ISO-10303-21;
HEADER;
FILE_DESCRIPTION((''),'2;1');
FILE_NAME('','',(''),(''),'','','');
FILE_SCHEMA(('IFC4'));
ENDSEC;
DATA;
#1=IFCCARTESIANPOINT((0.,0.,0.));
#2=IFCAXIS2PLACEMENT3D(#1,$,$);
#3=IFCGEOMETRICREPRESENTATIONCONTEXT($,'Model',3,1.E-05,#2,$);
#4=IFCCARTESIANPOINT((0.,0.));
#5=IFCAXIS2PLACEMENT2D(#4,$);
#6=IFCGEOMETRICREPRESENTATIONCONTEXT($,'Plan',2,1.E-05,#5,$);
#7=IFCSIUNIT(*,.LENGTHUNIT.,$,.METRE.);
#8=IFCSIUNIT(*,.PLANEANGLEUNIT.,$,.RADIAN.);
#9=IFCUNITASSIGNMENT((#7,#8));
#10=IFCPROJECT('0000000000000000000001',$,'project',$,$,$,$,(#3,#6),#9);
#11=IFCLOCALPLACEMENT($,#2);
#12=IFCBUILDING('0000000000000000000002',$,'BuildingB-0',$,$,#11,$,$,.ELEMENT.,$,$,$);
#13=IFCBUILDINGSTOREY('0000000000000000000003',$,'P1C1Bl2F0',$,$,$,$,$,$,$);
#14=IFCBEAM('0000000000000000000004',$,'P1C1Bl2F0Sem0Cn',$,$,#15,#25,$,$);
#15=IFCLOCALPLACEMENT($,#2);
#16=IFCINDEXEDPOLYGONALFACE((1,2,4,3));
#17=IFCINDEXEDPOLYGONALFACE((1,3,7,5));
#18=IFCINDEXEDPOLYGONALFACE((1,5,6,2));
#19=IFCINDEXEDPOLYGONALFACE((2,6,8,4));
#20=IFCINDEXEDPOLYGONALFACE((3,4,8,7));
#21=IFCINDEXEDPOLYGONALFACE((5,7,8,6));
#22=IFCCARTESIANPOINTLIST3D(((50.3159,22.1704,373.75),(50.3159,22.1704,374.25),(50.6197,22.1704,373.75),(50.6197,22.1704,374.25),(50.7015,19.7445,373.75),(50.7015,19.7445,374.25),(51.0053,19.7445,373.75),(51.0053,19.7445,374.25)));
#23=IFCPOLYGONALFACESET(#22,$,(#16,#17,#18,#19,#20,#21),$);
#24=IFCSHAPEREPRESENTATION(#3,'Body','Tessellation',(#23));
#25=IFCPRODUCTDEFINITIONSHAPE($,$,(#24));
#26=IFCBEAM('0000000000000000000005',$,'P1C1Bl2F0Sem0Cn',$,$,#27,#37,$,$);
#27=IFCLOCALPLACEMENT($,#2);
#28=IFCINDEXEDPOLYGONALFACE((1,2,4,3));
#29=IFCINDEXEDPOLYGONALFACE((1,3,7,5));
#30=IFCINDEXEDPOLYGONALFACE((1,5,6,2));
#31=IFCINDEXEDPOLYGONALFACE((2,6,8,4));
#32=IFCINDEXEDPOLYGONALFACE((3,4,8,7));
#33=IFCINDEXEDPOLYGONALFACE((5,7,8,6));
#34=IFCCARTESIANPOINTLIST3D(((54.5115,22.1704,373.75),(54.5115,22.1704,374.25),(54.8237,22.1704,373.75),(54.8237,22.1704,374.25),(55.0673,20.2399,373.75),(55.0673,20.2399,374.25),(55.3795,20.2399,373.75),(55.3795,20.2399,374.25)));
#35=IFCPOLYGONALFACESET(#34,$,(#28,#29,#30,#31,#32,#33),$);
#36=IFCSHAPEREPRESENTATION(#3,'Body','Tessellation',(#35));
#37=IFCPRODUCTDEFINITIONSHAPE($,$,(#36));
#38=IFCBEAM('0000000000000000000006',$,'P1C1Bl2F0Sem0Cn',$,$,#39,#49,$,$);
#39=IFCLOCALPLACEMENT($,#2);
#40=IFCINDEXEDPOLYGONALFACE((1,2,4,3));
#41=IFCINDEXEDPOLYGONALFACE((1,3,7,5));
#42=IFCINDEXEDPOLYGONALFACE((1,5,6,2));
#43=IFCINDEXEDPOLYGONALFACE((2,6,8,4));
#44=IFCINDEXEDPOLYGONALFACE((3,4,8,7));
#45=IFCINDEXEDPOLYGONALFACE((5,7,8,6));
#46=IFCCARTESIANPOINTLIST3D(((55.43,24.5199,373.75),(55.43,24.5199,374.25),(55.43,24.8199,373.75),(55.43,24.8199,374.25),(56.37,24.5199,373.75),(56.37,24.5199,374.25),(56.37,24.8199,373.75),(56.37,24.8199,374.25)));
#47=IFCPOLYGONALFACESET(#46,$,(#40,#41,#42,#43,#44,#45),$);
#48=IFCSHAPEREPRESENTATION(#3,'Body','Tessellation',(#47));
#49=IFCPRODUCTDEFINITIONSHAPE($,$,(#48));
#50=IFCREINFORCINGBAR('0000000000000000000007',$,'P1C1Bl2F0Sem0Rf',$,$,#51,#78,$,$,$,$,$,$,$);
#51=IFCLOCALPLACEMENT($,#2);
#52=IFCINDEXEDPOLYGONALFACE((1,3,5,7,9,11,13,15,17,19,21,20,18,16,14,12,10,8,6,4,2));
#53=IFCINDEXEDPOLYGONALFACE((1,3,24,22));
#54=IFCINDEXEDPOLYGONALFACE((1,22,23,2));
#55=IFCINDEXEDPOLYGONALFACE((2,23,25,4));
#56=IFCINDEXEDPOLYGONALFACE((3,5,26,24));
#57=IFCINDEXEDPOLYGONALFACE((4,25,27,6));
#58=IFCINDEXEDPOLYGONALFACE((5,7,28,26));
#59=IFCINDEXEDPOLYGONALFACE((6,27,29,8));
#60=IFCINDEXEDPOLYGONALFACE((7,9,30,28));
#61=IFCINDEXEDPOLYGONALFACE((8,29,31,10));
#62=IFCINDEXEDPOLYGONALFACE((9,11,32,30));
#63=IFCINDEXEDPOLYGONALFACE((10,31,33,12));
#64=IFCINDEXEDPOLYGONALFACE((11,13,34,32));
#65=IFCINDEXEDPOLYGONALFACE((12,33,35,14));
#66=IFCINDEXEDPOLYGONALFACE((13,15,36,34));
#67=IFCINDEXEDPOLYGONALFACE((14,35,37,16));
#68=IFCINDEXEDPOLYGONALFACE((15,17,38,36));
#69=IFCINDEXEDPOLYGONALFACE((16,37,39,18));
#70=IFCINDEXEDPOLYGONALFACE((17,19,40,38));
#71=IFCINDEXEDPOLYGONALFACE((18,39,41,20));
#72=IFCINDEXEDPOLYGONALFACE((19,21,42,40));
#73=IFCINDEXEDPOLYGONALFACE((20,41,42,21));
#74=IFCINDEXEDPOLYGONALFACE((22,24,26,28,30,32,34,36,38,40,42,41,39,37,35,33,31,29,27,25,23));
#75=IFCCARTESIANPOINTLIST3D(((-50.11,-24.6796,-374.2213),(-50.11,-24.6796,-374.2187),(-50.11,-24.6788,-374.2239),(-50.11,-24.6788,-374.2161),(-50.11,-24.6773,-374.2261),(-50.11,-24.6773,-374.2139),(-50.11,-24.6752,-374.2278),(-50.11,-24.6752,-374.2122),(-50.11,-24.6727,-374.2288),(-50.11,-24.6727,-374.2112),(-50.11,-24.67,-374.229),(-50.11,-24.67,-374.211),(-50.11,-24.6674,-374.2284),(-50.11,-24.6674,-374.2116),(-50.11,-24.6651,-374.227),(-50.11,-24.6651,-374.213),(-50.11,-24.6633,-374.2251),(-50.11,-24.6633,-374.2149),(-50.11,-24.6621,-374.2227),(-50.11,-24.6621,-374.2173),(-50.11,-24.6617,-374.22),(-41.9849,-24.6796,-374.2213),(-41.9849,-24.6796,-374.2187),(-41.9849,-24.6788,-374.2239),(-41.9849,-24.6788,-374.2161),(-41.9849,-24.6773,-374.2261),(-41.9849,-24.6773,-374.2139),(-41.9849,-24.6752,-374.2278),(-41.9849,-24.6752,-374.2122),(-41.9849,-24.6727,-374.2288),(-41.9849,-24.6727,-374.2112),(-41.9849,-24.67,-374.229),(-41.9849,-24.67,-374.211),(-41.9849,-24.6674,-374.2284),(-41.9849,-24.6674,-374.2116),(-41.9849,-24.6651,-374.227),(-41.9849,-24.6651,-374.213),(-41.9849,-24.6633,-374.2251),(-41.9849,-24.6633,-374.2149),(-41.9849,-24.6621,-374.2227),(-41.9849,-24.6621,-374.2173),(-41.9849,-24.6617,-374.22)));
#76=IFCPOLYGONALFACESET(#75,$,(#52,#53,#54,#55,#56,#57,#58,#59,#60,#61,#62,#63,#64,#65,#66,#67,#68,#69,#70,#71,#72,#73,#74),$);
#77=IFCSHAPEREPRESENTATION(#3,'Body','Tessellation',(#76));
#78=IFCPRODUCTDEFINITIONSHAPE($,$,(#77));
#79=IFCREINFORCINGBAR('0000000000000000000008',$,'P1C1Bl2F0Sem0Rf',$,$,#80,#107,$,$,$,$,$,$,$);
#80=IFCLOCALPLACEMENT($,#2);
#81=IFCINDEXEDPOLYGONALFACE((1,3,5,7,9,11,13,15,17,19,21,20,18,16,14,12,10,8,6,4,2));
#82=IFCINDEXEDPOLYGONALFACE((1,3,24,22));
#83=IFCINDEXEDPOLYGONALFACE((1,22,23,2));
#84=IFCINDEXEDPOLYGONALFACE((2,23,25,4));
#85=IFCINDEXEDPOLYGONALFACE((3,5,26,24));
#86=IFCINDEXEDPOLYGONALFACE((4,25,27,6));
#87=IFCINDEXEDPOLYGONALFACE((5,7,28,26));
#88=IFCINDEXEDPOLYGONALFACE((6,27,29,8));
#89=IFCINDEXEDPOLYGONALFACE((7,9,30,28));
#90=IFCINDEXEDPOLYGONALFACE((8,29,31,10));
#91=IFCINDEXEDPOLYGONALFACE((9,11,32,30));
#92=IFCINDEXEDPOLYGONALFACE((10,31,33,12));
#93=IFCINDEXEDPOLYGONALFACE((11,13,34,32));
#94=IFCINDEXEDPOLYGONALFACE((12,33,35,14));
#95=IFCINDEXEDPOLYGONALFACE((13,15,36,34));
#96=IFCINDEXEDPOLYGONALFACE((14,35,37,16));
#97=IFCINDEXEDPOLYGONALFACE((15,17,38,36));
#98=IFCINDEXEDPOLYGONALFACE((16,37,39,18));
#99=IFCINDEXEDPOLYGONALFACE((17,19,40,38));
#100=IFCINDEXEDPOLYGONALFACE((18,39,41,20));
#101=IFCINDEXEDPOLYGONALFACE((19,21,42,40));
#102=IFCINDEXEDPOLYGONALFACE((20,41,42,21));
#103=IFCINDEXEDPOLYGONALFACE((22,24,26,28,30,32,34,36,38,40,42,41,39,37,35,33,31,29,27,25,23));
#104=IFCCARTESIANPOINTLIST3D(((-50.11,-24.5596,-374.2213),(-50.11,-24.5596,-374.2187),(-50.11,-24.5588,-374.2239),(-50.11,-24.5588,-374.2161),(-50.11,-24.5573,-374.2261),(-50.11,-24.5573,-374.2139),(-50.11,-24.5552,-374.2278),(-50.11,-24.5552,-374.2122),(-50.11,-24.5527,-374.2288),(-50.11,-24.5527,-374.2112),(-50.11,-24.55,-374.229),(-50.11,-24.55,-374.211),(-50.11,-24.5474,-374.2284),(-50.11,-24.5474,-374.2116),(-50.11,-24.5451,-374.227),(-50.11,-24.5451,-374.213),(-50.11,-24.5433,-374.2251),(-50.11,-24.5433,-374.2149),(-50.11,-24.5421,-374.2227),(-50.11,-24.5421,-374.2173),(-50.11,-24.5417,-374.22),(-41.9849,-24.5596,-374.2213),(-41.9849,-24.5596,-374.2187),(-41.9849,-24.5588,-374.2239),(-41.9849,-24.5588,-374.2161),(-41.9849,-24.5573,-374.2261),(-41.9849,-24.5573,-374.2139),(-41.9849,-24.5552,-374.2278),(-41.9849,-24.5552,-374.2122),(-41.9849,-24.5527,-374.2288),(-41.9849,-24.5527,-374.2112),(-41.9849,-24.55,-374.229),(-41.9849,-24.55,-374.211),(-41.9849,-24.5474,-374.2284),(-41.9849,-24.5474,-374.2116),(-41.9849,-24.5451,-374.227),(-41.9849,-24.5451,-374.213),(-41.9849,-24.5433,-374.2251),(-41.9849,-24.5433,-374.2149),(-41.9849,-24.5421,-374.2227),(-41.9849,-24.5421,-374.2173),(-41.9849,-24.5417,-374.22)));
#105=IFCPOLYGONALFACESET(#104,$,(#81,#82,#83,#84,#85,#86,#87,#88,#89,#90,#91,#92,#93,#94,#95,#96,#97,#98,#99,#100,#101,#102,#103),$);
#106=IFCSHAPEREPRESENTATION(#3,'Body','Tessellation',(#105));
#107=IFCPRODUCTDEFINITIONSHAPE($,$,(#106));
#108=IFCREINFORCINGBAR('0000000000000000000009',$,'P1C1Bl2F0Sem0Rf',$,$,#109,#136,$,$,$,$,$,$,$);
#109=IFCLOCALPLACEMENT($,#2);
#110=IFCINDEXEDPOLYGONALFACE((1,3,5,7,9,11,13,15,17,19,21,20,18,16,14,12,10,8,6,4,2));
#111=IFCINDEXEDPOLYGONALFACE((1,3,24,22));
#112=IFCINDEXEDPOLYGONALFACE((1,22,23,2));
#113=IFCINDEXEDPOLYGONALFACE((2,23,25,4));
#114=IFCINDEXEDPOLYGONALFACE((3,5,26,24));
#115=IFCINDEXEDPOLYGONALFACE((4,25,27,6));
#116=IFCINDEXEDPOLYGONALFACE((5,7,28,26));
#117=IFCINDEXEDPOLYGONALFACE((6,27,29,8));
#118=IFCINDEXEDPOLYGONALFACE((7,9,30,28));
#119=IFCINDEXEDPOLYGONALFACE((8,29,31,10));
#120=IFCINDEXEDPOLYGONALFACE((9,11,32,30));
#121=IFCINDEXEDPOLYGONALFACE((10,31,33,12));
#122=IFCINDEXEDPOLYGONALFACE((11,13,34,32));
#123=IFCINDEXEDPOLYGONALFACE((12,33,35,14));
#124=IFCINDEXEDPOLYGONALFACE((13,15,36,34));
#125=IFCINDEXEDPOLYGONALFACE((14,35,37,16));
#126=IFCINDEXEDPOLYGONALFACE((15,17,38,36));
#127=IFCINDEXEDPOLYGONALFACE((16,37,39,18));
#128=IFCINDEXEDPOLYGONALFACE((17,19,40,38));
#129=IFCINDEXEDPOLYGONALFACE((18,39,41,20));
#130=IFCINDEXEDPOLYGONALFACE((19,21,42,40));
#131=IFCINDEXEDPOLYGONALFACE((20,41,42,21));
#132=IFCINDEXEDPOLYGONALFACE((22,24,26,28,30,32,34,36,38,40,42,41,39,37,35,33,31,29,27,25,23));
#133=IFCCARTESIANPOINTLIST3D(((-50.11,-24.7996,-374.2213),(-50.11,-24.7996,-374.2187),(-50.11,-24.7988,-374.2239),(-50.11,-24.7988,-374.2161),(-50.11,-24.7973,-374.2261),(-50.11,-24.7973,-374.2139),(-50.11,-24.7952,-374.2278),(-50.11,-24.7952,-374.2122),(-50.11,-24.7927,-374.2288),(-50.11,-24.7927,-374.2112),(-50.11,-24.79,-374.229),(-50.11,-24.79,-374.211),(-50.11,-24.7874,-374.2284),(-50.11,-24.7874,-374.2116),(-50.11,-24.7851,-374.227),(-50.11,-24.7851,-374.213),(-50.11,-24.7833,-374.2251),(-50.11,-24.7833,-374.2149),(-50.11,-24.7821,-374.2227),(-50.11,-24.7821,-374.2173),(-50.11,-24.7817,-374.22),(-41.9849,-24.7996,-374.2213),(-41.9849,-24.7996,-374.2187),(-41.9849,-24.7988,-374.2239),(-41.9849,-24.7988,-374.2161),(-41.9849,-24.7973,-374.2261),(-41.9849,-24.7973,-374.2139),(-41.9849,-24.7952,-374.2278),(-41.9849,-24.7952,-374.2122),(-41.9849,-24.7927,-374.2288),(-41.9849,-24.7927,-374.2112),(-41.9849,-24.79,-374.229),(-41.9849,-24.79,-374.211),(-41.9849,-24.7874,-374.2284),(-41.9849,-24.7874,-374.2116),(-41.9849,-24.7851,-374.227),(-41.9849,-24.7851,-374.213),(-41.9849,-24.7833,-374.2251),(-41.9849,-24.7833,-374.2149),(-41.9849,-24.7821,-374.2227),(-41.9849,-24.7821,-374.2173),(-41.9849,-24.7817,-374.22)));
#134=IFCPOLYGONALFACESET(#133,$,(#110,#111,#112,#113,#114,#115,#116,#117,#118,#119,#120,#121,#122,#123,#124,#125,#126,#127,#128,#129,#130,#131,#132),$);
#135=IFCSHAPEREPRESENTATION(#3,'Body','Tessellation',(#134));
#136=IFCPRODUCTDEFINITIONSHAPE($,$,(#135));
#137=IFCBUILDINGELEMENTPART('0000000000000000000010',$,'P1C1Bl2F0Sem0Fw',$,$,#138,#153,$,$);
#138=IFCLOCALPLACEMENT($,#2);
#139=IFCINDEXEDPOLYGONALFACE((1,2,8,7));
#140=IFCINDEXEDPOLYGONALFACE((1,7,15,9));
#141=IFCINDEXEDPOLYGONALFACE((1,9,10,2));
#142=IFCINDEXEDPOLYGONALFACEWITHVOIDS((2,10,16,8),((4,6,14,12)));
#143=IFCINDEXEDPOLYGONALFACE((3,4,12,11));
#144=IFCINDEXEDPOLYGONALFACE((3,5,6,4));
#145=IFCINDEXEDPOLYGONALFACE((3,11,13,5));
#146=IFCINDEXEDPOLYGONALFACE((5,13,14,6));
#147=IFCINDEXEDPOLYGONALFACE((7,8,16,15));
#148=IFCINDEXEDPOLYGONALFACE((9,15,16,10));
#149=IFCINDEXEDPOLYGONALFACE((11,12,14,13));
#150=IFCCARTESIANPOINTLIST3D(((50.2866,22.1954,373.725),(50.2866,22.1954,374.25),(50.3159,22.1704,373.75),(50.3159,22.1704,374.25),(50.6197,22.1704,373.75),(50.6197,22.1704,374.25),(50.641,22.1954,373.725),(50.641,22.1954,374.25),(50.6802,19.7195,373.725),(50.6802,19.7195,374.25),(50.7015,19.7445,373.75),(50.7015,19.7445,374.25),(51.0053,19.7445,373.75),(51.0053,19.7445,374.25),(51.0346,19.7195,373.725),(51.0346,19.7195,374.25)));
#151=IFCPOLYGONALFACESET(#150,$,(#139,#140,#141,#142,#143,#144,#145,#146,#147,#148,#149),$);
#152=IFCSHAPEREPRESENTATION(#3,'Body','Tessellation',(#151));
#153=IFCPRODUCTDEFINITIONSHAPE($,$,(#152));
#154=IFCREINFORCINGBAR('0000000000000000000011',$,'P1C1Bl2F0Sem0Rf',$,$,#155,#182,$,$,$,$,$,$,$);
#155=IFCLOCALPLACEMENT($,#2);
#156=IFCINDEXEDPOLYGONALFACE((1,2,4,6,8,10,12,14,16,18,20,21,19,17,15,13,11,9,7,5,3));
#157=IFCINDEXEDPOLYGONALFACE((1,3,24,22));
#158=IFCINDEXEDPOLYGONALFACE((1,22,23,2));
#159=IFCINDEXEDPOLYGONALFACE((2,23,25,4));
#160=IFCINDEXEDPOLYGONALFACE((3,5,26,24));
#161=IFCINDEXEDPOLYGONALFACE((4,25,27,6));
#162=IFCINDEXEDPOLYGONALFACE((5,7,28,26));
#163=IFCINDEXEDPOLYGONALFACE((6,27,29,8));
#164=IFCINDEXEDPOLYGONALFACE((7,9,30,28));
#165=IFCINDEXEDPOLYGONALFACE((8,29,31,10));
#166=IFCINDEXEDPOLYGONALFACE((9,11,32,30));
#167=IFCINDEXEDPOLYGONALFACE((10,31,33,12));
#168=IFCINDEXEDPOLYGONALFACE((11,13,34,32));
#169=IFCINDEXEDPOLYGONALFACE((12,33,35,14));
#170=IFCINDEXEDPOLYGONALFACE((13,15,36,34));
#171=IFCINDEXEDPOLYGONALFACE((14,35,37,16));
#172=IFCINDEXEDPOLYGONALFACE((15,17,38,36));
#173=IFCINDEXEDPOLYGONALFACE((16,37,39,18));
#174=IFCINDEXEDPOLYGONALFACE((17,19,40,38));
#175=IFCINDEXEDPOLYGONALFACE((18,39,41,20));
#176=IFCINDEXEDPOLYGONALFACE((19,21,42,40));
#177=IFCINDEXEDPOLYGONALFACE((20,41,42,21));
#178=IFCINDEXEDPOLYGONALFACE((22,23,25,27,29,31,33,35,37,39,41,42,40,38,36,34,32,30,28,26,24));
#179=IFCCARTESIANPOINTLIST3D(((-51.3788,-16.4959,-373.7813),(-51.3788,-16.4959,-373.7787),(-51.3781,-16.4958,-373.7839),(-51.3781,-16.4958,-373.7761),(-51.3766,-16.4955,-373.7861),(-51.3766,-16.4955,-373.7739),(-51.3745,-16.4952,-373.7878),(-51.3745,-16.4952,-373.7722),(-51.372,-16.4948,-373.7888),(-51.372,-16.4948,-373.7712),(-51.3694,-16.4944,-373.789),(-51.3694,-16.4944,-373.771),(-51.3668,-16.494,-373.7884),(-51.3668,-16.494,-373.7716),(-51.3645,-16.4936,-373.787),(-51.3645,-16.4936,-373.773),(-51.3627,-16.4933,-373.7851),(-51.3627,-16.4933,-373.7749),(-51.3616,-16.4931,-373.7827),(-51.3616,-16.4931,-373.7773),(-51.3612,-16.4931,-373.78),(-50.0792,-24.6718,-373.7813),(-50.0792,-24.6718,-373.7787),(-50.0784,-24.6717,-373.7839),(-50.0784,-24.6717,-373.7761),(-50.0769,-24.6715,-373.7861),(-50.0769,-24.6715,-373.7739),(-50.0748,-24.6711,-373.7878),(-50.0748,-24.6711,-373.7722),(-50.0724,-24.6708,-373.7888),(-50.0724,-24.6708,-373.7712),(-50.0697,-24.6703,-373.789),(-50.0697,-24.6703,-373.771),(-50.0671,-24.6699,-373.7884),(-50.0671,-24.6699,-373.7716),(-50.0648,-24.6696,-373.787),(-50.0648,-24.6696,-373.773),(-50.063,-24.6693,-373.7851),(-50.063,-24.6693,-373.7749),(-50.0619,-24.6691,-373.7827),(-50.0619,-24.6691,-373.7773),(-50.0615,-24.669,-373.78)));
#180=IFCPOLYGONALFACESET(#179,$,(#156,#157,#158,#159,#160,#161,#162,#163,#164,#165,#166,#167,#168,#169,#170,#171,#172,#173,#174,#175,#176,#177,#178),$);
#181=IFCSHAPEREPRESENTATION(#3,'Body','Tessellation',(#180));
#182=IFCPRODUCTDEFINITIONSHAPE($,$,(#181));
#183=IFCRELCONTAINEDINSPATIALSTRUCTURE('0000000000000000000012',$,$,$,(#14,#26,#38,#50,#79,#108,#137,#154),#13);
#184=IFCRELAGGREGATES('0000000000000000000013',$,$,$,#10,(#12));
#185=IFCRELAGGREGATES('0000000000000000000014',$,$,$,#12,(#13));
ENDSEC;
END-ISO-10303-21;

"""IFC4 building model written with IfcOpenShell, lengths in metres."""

from ifc_helpers import new_model, entity, si_unit, origin, origin_2d, place, context, project, spatial, polyline, outline, extrude, element, save


model = new_model("IFC4")

# Units and contexts
model_context = context("Model", 3, precision=1e-05, world=origin())
plan_context = context("Plan", 2, precision=1e-05, world=origin_2d())
ifc_project = project(units=[si_unit("LENGTHUNIT", "METRE"), si_unit("PLANEANGLEUNIT", "RADIAN")], contexts=[model_context, plan_context])

# Building, storey
building_placement = place(None, origin())
building = spatial("IfcBuilding", under=ifc_project, at=building_placement, Name="BuildingB-0", CompositionType="ELEMENT")
storey = spatial("IfcBuildingStorey", under=building, Name="P1C1Bl2F0")

# Beams
element("IfcBeam", 1, inside=storey, Name="P1C1Bl2F0Sem0Cn", context=model_context, shape_type="SweptSolid", body=[
    extrude(outline(polyline([(50.7015, 19.7445, 373.75), (51.0053, 19.7445, 373.75), (50.6197, 22.1704, 373.75), (50.3159, 22.1704, 373.75), (50.7015, 19.7445, 373.75)])), None, (0.0, 0.0, 1.0), 0.5),
])
element("IfcBeam", 2, inside=storey, Name="P1C1Bl2F0Sem0Cn", context=model_context, shape_type="SweptSolid", body=[
    extrude(outline(polyline([(55.0673, 20.2399, 373.75), (55.3795, 20.2399, 373.75), (54.8237, 22.1704, 373.75), (54.5115, 22.1704, 373.75), (55.0673, 20.2399, 373.75)])), None, (0.0, 0.0, 1.0), 0.5),
])
element("IfcBeam", 3, inside=storey, Name="P1C1Bl2F0Sem0Cn", context=model_context, shape_type="SweptSolid", body=[
    extrude(outline(polyline([(55.43, 24.5199, 373.75), (55.43, 24.8199, 373.75), (56.37, 24.8199, 373.75), (56.37, 24.5199, 373.75), (55.43, 24.5199, 373.75)])), None, (0.0, 0.0, 1.0), 0.5),
])

# Reinforcing bars
element("IfcReinforcingBar", 4, inside=storey, Name="P1C1Bl2F0Sem0Rf", context=model_context, shape_type="SweptSolid", body=[
    entity("IfcSurfaceCurveSweptAreaSolid", entity("IfcCircleProfileDef", "AREA", None, None, 0.009), None, entity("IfcPolyline", [entity("IfcCartesianPoint", [41.9849, 24.6707, 374.22]), entity("IfcCartesianPoint", [50.11, 24.6707, 374.22])]), None, None, entity("IfcPlane", entity("IfcAxis2Placement3D", entity("IfcCartesianPoint", [41.9849, 24.6707, 374.22]), entity("IfcDirection", [0.0, 0.0, 1.0]), entity("IfcDirection", [1.0, 0.0, 0.0])))),
])
element("IfcReinforcingBar", 5, inside=storey, Name="P1C1Bl2F0Sem0Rf", context=model_context, shape_type="SweptSolid", body=[
    entity("IfcSurfaceCurveSweptAreaSolid", entity("IfcCircleProfileDef", "AREA", None, None, 0.009), None, entity("IfcPolyline", [entity("IfcCartesianPoint", [41.9849, 24.5507, 374.22]), entity("IfcCartesianPoint", [50.11, 24.5507, 374.22])]), None, None, entity("IfcPlane", entity("IfcAxis2Placement3D", entity("IfcCartesianPoint", [41.9849, 24.5507, 374.22]), entity("IfcDirection", [0.0, 0.0, 1.0]), entity("IfcDirection", [1.0, 0.0, 0.0])))),
])
element("IfcReinforcingBar", 6, inside=storey, Name="P1C1Bl2F0Sem0Rf", context=model_context, shape_type="SweptSolid", body=[
    entity("IfcSurfaceCurveSweptAreaSolid", entity("IfcCircleProfileDef", "AREA", None, None, 0.009), None, entity("IfcPolyline", [entity("IfcCartesianPoint", [41.9849, 24.7907, 374.22]), entity("IfcCartesianPoint", [50.11, 24.7907, 374.22])]), None, None, entity("IfcPlane", entity("IfcAxis2Placement3D", entity("IfcCartesianPoint", [41.9849, 24.7907, 374.22]), entity("IfcDirection", [0.0, 0.0, 1.0]), entity("IfcDirection", [1.0, 0.0, 0.0])))),
])

# Building element part, opening
building_element_part_1 = element("IfcBuildingElementPart", 7, inside=storey, Name="P1C1Bl2F0Sem0Fw", context=model_context, shape_type="SweptSolid", body=[
    extrude(outline(polyline([(50.6802, 19.7195, 373.725), (51.0346, 19.7195, 373.725), (50.641, 22.1954, 373.725), (50.2866, 22.1954, 373.725), (50.6802, 19.7195, 373.725)])), None, (0.0, 0.0, 1.0), 0.525),
])
element("IfcOpeningElement", 8, inside=storey, cuts=building_element_part_1, context=model_context, shape_type="SweptSolid", body=[
    extrude(outline(polyline([(50.7015, 19.7445, 373.75), (51.0053, 19.7445, 373.75), (50.6197, 22.1704, 373.75), (50.3159, 22.1704, 373.75), (50.7015, 19.7445, 373.75)])), None, (0.0, 0.0, 1.0), 0.5),
])

# Reinforcing bar
element("IfcReinforcingBar", 9, inside=storey, Name="P1C1Bl2F0Sem0Rf", context=model_context, shape_type="SweptSolid", body=[
    entity("IfcSurfaceCurveSweptAreaSolid", entity("IfcCircleProfileDef", "AREA", None, None, 0.009), None, entity("IfcPolyline", [entity("IfcCartesianPoint", [51.3701, 16.4945, 373.78]), entity("IfcCartesianPoint", [50.0704, 24.6704, 373.78])]), None, None, entity("IfcPlane", entity("IfcAxis2Placement3D", entity("IfcCartesianPoint", [51.3701, 16.4945, 373.78]), entity("IfcDirection", [0.0, 0.0, 1.0]), entity("IfcDirection", [1.0, 0.0, 0.0])))),
])

save(model, "model.ifc")
